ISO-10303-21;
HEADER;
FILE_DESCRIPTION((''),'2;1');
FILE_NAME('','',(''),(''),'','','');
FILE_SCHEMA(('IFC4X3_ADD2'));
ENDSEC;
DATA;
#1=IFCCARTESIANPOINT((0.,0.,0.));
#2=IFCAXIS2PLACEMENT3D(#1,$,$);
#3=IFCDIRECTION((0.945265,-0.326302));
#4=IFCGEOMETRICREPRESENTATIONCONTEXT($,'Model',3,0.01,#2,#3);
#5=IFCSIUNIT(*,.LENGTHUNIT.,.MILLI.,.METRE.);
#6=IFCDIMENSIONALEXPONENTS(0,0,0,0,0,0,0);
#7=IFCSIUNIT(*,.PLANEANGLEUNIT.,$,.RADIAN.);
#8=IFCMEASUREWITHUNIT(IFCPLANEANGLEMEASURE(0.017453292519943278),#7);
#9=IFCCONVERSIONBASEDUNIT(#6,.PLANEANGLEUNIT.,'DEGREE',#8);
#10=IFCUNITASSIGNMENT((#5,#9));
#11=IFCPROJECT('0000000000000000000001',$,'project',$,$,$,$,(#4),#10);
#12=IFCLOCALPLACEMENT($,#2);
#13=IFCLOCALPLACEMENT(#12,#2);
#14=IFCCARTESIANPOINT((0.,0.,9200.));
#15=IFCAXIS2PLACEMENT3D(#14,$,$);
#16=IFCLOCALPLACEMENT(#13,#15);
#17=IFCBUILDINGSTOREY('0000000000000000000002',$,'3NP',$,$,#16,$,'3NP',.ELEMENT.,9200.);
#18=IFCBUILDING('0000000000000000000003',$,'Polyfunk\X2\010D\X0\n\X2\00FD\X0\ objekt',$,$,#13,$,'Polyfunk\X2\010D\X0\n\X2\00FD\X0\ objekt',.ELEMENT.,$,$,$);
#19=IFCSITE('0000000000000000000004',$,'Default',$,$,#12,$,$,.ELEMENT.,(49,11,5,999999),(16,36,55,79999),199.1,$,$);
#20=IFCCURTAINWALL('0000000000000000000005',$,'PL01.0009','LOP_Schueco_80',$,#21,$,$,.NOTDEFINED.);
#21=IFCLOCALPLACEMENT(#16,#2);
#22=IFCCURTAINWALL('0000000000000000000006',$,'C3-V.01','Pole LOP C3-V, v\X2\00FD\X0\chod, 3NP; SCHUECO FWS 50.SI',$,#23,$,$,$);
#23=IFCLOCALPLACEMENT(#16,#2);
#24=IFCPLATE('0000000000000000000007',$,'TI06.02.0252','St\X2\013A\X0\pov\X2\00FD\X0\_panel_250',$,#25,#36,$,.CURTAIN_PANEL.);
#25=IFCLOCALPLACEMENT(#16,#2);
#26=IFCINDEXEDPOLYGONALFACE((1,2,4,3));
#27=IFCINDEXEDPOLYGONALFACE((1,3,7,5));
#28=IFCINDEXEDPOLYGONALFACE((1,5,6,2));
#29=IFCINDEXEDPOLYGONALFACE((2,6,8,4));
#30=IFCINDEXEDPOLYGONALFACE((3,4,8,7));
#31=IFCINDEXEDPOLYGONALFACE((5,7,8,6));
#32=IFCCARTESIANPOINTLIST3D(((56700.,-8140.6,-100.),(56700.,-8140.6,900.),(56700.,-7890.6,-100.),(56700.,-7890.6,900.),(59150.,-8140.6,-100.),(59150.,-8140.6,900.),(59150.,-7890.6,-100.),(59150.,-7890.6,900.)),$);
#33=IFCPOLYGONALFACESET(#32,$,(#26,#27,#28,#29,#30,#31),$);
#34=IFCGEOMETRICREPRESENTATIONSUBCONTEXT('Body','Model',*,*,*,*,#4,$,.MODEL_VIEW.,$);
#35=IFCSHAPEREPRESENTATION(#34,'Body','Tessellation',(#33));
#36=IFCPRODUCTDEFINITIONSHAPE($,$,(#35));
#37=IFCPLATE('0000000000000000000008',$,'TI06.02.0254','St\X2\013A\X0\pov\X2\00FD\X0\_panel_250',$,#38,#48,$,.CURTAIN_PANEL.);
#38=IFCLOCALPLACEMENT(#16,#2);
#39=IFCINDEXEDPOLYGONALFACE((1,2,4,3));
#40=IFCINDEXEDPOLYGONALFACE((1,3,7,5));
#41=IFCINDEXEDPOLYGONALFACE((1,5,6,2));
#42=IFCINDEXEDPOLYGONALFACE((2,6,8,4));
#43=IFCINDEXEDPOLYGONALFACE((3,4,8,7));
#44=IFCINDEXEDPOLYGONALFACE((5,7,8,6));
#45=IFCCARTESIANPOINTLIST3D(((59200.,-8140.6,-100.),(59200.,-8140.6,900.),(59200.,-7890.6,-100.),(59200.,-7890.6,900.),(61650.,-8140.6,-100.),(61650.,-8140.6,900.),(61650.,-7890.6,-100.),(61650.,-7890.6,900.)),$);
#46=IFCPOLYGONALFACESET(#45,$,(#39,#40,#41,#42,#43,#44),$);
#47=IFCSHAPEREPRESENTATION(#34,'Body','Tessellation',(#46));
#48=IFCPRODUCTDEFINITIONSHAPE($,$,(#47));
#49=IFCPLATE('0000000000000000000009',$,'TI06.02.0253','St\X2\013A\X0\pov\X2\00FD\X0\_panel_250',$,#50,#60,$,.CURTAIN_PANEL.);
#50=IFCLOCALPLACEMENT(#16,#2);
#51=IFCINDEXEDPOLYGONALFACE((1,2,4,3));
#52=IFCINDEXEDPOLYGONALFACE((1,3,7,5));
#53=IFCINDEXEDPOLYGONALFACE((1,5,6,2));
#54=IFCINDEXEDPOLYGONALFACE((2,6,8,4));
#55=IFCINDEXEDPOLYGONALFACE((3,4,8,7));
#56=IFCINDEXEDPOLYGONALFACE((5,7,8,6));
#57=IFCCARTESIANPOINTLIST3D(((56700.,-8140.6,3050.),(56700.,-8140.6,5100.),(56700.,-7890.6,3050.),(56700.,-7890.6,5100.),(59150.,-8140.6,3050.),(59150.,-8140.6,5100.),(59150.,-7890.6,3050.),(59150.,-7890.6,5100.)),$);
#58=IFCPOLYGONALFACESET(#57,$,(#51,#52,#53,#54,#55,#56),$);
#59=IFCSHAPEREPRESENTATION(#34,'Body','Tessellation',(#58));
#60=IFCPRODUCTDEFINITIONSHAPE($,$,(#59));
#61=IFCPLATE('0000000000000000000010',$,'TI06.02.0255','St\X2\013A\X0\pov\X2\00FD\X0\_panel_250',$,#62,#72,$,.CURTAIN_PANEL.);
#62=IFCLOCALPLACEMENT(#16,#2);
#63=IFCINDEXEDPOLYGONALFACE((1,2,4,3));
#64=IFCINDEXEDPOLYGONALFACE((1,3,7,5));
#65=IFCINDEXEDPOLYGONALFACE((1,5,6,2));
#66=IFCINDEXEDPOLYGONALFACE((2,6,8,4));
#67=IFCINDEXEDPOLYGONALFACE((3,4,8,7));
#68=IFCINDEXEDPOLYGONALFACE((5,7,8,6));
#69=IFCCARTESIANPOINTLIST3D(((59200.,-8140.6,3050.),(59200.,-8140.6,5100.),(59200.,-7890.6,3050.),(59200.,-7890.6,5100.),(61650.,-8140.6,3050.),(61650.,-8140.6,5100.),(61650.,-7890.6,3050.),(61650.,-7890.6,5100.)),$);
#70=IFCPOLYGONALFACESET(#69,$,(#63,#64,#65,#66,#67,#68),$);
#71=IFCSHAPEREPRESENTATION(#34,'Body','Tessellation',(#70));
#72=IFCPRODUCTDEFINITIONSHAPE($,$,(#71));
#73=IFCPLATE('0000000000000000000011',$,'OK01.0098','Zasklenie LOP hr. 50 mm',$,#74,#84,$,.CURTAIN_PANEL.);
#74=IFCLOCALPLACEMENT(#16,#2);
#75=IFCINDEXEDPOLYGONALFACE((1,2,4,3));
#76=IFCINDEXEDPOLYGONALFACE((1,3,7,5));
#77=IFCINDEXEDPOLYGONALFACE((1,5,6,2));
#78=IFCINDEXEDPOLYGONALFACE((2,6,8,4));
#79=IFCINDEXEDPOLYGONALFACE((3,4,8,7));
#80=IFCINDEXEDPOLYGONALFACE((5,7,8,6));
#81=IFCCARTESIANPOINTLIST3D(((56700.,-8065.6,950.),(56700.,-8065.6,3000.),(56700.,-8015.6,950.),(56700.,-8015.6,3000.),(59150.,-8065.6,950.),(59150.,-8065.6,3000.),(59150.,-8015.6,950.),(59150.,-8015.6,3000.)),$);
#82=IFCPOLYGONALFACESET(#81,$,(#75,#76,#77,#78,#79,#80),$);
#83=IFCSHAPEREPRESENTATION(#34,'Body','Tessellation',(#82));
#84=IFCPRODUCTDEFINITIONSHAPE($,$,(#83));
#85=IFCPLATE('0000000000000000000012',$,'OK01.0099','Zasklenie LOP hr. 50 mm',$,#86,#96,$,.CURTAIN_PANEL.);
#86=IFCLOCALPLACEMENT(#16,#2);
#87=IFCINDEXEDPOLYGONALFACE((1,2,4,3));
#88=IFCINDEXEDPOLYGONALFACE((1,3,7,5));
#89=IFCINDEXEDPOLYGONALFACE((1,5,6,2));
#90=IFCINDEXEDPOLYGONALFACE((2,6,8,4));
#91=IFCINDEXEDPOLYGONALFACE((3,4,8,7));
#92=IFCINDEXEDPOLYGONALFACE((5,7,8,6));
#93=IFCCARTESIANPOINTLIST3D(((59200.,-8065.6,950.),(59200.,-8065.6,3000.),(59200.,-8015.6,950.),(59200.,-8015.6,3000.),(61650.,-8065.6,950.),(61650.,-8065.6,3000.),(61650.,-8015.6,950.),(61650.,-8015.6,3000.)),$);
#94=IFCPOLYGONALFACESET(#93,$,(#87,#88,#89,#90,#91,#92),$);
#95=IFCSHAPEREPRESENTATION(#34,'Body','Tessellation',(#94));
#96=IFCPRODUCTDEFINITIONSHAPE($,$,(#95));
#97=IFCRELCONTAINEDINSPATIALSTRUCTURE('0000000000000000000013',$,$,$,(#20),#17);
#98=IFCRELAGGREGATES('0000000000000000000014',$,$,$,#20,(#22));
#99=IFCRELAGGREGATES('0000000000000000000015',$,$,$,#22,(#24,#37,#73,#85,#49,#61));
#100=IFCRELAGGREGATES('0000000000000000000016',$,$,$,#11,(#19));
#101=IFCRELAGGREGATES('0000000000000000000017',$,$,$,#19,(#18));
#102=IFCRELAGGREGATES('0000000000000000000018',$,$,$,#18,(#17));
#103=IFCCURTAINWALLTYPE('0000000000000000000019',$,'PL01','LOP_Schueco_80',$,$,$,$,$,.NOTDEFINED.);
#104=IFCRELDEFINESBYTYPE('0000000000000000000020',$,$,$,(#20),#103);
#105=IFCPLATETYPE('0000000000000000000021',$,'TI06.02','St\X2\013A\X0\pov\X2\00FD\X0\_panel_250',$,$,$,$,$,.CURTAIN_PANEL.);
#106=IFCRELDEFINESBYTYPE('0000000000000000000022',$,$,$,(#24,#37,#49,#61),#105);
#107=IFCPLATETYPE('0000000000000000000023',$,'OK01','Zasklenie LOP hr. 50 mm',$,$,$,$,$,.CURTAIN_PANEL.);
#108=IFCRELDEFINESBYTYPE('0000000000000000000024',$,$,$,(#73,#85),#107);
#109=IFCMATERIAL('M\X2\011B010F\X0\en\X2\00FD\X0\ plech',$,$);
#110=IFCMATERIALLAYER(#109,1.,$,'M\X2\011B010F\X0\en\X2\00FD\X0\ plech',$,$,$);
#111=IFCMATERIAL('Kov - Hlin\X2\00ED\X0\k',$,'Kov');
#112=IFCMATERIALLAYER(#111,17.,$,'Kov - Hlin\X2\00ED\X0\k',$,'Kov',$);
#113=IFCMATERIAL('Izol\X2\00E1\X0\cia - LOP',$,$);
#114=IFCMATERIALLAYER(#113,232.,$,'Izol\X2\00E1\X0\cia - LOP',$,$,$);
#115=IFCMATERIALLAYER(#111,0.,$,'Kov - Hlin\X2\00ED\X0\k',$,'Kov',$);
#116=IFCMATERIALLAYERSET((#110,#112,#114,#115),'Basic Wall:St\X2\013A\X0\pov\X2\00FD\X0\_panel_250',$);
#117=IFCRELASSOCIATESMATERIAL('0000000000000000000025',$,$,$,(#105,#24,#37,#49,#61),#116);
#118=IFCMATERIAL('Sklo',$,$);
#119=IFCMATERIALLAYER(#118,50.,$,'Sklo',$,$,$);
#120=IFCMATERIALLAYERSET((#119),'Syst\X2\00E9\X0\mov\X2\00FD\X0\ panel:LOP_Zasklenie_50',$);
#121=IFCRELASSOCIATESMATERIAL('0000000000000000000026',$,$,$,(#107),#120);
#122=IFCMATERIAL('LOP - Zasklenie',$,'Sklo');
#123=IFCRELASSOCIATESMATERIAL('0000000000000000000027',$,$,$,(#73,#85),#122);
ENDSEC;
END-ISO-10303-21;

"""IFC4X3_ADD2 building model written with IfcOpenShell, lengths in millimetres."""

from ifc_helpers import new_model, entity, si_unit, converted_unit, direction, frame, frame_2d, origin, origin_2d_with_axis, place, context, subcontext, project, spatial, rectangle, extrude, source, transform, mapped, material, layer, layer_set, layer_usage, type_object, type_shapes, element, aggregate, save


model = new_model("IFC4X3_ADD2")

# Units and contexts
model_context = context("Model", 3, precision=0.01, world=origin(), true_north=direction((0.945265, -0.326302)))
body_context = subcontext(model_context, "Body", "Model", "MODEL_VIEW")
ifc_project = project(units=[si_unit("LENGTHUNIT", "METRE", prefix="MILLI"), converted_unit("PLANEANGLEUNIT", "DEGREE", entity("IfcPlaneAngleMeasure", 0.017453292519943278), si_unit("PLANEANGLEUNIT", "RADIAN"), dimensions=[0, 0, 0, 0, 0, 0, 0])], contexts=[model_context])

# Site, building, storey
site_placement = place(None, origin())
site = spatial("IfcSite", under=ifc_project, at=site_placement, Name="Default", CompositionType="ELEMENT", RefLatitude=(49, 11, 5, 999999), RefLongitude=(16, 36, 55, 79999), RefElevation=199.1)
building_placement = place(site_placement, origin())
building = spatial("IfcBuilding", under=site, at=building_placement, Name="Polyfunkčný objekt", LongName="Polyfunkčný objekt", CompositionType="ELEMENT")
storey_placement = place(building_placement, frame((0.0, 0.0, 9200.0)))
storey = spatial("IfcBuildingStorey", under=building, at=storey_placement, Name="3NP", LongName="3NP", CompositionType="ELEMENT", Elevation=9200.0)

# Curtain walls, plates
curtain_wall_type = type_object("IfcCurtainWallType", Name="PL01", Description="LOP_Schueco_80", PredefinedType="NOTDEFINED")
curtain_wall_1_placement = place(storey_placement, frame((0.0, 0.0, -9200.0)))
curtain_wall_1 = element("IfcCurtainWall", 1, at=curtain_wall_1_placement, inside=storey, type_object=curtain_wall_type, Name="PL01.0009", Description="LOP_Schueco_80", PredefinedType="NOTDEFINED")
curtain_wall_2 = element("IfcCurtainWall", 2, Name="C3-V.01", Description="Pole LOP C3-V, východ, 3NP; SCHUECO FWS 50.SI")
aggregate(curtain_wall_1, [curtain_wall_2])
ifc_material_1 = material(Name="Měďený plech")
ifc_layer_1 = layer(ifc_material_1, 1.0, Name="Měďený plech")
ifc_material_2 = material(Name="Kov - Hliník", Category="Kov")
ifc_layer_2 = layer(ifc_material_2, 17.0, Name="Kov - Hliník", Category="Kov")
ifc_material_3 = material(Name="Izolácia - LOP")
ifc_layer_3 = layer(ifc_material_3, 232.0, Name="Izolácia - LOP")
ifc_layer_4 = layer(ifc_material_2, 0.0, Name="Kov - Hliník", Category="Kov")
ifc_layer_set_1 = layer_set([ifc_layer_1, ifc_layer_2, ifc_layer_3, ifc_layer_4], Name="Basic Wall:Stĺpový_panel_250")
ifc_layer_usage_1 = layer_usage(ifc_layer_set_1, "AXIS2", "POSITIVE", -125.0)
plate_type_1 = type_object("IfcPlateType", Name="TI06.02", Description="Stĺpový_panel_250", PredefinedType="CURTAIN_PANEL", material=ifc_layer_set_1)
plate_1_placement = place(storey_placement, frame((56700.0, -8015.6, -100.0)))
plate_1 = element("IfcPlate", 3, at=plate_1_placement, type_object=plate_type_1, material=ifc_layer_usage_1, Name="TI06.02.0252", Description="Stĺpový_panel_250", PredefinedType="CURTAIN_PANEL", context=body_context, shape_type="SweptSolid", body=[
    extrude(rectangle(XDim=250.0, YDim=2450.0, at=frame_2d((0.0, 0.0), x_axis=(1.0, 0.0))), frame((1225.0, 0.0, 0.0), z_axis=(0.0, 0.0, 1.0), x_axis=(0.0, 1.0, 0.0)), (0.0, 0.0, 1.0), 1000.0),
])
ifc_layer_usage_2 = layer_usage(ifc_layer_set_1, "AXIS2", "POSITIVE", -125.0)
plate_2_placement = place(storey_placement, frame((59200.0, -8015.6, -100.0)))
plate_2 = element("IfcPlate", 4, at=plate_2_placement, type_object=plate_type_1, material=ifc_layer_usage_2, Name="TI06.02.0254", Description="Stĺpový_panel_250", PredefinedType="CURTAIN_PANEL", context=body_context, shape_type="SweptSolid", body=[
    extrude(rectangle(XDim=250.0, YDim=2450.0, at=frame_2d((0.0, 0.0), x_axis=(1.0, 0.0))), frame((1225.0, 0.0, 0.0), z_axis=(0.0, 0.0, 1.0), x_axis=(0.0, 1.0, 0.0)), (0.0, 0.0, 1.0), 1000.0),
])
ifc_layer_usage_3 = layer_usage(ifc_layer_set_1, "AXIS2", "POSITIVE", -125.0)
plate_3_placement = place(storey_placement, frame((56700.0, -8015.6, 3050.0)))
plate_3 = element("IfcPlate", 5, at=plate_3_placement, type_object=plate_type_1, material=ifc_layer_usage_3, Name="TI06.02.0253", Description="Stĺpový_panel_250", PredefinedType="CURTAIN_PANEL", context=body_context, shape_type="SweptSolid", body=[
    extrude(rectangle(XDim=250.0, YDim=2450.0, at=frame_2d((0.0, 0.0), x_axis=(1.0, 0.0))), frame((1225.0, 0.0, 0.0), z_axis=(0.0, 0.0, 1.0), x_axis=(0.0, 1.0, 0.0)), (0.0, 0.0, 1.0), 2050.0),
])
ifc_layer_usage_4 = layer_usage(ifc_layer_set_1, "AXIS2", "POSITIVE", -125.0)
plate_4_placement = place(storey_placement, frame((59200.0, -8015.6, 3050.0)))
plate_4 = element("IfcPlate", 6, at=plate_4_placement, type_object=plate_type_1, material=ifc_layer_usage_4, Name="TI06.02.0255", Description="Stĺpový_panel_250", PredefinedType="CURTAIN_PANEL", context=body_context, shape_type="SweptSolid", body=[
    extrude(rectangle(XDim=250.0, YDim=2450.0, at=frame_2d((0.0, 0.0), x_axis=(1.0, 0.0))), frame((1225.0, 0.0, 0.0), z_axis=(0.0, 0.0, 1.0), x_axis=(0.0, 1.0, 0.0)), (0.0, 0.0, 1.0), 2050.0),
])
ifc_material_4 = material(Name="LOP - Zasklenie", Category="Sklo")
ifc_material_5 = material(Name="Sklo")
ifc_layer_5 = layer(ifc_material_5, 50.0, Name="Sklo")
ifc_layer_set_2 = layer_set([ifc_layer_5], Name="Systémový panel:LOP_Zasklenie_50")
plate_type_2 = type_object("IfcPlateType", Name="OK01", Description="Zasklenie LOP hr. 50 mm", PredefinedType="CURTAIN_PANEL", material=ifc_layer_set_2)
shared_shape_1 = source(origin(), body_context, "Body", "SweptSolid", [
    extrude(rectangle(XDim=50.0, YDim=2450.0, at=origin_2d_with_axis()), frame((0.0, -25.0, 0.0), z_axis=(0.0, 0.0, 1.0), x_axis=(0.0, 1.0, 0.0)), (0.0, 0.0, 1.0), 2050.0),
])
type_shapes(plate_type_2, [shared_shape_1])
plate_5_placement = place(curtain_wall_1_placement, frame((57925.0, -8015.6, 10150.0)))
plate_5 = element("IfcPlate", 7, at=plate_5_placement, type_object=plate_type_2, material=ifc_material_4, Name="OK01.0098", Description="Zasklenie LOP hr. 50 mm", PredefinedType="CURTAIN_PANEL", context=body_context, shape_type="MappedRepresentation", body=[
    mapped(shared_shape_1, transform((0.0, 0.0, 0.0), scale=1.0)),
])
plate_6_placement = place(curtain_wall_1_placement, frame((60425.0, -8015.6, 10150.0)))
plate_6 = element("IfcPlate", 8, at=plate_6_placement, type_object=plate_type_2, material=ifc_material_4, Name="OK01.0099", Description="Zasklenie LOP hr. 50 mm", PredefinedType="CURTAIN_PANEL", context=body_context, shape_type="MappedRepresentation", body=[
    mapped(shared_shape_1, transform((0.0, 0.0, 0.0), scale=1.0)),
])
aggregate(curtain_wall_2, [plate_1, plate_2, plate_5, plate_6, plate_3, plate_4])

save(model, "model.ifc")
